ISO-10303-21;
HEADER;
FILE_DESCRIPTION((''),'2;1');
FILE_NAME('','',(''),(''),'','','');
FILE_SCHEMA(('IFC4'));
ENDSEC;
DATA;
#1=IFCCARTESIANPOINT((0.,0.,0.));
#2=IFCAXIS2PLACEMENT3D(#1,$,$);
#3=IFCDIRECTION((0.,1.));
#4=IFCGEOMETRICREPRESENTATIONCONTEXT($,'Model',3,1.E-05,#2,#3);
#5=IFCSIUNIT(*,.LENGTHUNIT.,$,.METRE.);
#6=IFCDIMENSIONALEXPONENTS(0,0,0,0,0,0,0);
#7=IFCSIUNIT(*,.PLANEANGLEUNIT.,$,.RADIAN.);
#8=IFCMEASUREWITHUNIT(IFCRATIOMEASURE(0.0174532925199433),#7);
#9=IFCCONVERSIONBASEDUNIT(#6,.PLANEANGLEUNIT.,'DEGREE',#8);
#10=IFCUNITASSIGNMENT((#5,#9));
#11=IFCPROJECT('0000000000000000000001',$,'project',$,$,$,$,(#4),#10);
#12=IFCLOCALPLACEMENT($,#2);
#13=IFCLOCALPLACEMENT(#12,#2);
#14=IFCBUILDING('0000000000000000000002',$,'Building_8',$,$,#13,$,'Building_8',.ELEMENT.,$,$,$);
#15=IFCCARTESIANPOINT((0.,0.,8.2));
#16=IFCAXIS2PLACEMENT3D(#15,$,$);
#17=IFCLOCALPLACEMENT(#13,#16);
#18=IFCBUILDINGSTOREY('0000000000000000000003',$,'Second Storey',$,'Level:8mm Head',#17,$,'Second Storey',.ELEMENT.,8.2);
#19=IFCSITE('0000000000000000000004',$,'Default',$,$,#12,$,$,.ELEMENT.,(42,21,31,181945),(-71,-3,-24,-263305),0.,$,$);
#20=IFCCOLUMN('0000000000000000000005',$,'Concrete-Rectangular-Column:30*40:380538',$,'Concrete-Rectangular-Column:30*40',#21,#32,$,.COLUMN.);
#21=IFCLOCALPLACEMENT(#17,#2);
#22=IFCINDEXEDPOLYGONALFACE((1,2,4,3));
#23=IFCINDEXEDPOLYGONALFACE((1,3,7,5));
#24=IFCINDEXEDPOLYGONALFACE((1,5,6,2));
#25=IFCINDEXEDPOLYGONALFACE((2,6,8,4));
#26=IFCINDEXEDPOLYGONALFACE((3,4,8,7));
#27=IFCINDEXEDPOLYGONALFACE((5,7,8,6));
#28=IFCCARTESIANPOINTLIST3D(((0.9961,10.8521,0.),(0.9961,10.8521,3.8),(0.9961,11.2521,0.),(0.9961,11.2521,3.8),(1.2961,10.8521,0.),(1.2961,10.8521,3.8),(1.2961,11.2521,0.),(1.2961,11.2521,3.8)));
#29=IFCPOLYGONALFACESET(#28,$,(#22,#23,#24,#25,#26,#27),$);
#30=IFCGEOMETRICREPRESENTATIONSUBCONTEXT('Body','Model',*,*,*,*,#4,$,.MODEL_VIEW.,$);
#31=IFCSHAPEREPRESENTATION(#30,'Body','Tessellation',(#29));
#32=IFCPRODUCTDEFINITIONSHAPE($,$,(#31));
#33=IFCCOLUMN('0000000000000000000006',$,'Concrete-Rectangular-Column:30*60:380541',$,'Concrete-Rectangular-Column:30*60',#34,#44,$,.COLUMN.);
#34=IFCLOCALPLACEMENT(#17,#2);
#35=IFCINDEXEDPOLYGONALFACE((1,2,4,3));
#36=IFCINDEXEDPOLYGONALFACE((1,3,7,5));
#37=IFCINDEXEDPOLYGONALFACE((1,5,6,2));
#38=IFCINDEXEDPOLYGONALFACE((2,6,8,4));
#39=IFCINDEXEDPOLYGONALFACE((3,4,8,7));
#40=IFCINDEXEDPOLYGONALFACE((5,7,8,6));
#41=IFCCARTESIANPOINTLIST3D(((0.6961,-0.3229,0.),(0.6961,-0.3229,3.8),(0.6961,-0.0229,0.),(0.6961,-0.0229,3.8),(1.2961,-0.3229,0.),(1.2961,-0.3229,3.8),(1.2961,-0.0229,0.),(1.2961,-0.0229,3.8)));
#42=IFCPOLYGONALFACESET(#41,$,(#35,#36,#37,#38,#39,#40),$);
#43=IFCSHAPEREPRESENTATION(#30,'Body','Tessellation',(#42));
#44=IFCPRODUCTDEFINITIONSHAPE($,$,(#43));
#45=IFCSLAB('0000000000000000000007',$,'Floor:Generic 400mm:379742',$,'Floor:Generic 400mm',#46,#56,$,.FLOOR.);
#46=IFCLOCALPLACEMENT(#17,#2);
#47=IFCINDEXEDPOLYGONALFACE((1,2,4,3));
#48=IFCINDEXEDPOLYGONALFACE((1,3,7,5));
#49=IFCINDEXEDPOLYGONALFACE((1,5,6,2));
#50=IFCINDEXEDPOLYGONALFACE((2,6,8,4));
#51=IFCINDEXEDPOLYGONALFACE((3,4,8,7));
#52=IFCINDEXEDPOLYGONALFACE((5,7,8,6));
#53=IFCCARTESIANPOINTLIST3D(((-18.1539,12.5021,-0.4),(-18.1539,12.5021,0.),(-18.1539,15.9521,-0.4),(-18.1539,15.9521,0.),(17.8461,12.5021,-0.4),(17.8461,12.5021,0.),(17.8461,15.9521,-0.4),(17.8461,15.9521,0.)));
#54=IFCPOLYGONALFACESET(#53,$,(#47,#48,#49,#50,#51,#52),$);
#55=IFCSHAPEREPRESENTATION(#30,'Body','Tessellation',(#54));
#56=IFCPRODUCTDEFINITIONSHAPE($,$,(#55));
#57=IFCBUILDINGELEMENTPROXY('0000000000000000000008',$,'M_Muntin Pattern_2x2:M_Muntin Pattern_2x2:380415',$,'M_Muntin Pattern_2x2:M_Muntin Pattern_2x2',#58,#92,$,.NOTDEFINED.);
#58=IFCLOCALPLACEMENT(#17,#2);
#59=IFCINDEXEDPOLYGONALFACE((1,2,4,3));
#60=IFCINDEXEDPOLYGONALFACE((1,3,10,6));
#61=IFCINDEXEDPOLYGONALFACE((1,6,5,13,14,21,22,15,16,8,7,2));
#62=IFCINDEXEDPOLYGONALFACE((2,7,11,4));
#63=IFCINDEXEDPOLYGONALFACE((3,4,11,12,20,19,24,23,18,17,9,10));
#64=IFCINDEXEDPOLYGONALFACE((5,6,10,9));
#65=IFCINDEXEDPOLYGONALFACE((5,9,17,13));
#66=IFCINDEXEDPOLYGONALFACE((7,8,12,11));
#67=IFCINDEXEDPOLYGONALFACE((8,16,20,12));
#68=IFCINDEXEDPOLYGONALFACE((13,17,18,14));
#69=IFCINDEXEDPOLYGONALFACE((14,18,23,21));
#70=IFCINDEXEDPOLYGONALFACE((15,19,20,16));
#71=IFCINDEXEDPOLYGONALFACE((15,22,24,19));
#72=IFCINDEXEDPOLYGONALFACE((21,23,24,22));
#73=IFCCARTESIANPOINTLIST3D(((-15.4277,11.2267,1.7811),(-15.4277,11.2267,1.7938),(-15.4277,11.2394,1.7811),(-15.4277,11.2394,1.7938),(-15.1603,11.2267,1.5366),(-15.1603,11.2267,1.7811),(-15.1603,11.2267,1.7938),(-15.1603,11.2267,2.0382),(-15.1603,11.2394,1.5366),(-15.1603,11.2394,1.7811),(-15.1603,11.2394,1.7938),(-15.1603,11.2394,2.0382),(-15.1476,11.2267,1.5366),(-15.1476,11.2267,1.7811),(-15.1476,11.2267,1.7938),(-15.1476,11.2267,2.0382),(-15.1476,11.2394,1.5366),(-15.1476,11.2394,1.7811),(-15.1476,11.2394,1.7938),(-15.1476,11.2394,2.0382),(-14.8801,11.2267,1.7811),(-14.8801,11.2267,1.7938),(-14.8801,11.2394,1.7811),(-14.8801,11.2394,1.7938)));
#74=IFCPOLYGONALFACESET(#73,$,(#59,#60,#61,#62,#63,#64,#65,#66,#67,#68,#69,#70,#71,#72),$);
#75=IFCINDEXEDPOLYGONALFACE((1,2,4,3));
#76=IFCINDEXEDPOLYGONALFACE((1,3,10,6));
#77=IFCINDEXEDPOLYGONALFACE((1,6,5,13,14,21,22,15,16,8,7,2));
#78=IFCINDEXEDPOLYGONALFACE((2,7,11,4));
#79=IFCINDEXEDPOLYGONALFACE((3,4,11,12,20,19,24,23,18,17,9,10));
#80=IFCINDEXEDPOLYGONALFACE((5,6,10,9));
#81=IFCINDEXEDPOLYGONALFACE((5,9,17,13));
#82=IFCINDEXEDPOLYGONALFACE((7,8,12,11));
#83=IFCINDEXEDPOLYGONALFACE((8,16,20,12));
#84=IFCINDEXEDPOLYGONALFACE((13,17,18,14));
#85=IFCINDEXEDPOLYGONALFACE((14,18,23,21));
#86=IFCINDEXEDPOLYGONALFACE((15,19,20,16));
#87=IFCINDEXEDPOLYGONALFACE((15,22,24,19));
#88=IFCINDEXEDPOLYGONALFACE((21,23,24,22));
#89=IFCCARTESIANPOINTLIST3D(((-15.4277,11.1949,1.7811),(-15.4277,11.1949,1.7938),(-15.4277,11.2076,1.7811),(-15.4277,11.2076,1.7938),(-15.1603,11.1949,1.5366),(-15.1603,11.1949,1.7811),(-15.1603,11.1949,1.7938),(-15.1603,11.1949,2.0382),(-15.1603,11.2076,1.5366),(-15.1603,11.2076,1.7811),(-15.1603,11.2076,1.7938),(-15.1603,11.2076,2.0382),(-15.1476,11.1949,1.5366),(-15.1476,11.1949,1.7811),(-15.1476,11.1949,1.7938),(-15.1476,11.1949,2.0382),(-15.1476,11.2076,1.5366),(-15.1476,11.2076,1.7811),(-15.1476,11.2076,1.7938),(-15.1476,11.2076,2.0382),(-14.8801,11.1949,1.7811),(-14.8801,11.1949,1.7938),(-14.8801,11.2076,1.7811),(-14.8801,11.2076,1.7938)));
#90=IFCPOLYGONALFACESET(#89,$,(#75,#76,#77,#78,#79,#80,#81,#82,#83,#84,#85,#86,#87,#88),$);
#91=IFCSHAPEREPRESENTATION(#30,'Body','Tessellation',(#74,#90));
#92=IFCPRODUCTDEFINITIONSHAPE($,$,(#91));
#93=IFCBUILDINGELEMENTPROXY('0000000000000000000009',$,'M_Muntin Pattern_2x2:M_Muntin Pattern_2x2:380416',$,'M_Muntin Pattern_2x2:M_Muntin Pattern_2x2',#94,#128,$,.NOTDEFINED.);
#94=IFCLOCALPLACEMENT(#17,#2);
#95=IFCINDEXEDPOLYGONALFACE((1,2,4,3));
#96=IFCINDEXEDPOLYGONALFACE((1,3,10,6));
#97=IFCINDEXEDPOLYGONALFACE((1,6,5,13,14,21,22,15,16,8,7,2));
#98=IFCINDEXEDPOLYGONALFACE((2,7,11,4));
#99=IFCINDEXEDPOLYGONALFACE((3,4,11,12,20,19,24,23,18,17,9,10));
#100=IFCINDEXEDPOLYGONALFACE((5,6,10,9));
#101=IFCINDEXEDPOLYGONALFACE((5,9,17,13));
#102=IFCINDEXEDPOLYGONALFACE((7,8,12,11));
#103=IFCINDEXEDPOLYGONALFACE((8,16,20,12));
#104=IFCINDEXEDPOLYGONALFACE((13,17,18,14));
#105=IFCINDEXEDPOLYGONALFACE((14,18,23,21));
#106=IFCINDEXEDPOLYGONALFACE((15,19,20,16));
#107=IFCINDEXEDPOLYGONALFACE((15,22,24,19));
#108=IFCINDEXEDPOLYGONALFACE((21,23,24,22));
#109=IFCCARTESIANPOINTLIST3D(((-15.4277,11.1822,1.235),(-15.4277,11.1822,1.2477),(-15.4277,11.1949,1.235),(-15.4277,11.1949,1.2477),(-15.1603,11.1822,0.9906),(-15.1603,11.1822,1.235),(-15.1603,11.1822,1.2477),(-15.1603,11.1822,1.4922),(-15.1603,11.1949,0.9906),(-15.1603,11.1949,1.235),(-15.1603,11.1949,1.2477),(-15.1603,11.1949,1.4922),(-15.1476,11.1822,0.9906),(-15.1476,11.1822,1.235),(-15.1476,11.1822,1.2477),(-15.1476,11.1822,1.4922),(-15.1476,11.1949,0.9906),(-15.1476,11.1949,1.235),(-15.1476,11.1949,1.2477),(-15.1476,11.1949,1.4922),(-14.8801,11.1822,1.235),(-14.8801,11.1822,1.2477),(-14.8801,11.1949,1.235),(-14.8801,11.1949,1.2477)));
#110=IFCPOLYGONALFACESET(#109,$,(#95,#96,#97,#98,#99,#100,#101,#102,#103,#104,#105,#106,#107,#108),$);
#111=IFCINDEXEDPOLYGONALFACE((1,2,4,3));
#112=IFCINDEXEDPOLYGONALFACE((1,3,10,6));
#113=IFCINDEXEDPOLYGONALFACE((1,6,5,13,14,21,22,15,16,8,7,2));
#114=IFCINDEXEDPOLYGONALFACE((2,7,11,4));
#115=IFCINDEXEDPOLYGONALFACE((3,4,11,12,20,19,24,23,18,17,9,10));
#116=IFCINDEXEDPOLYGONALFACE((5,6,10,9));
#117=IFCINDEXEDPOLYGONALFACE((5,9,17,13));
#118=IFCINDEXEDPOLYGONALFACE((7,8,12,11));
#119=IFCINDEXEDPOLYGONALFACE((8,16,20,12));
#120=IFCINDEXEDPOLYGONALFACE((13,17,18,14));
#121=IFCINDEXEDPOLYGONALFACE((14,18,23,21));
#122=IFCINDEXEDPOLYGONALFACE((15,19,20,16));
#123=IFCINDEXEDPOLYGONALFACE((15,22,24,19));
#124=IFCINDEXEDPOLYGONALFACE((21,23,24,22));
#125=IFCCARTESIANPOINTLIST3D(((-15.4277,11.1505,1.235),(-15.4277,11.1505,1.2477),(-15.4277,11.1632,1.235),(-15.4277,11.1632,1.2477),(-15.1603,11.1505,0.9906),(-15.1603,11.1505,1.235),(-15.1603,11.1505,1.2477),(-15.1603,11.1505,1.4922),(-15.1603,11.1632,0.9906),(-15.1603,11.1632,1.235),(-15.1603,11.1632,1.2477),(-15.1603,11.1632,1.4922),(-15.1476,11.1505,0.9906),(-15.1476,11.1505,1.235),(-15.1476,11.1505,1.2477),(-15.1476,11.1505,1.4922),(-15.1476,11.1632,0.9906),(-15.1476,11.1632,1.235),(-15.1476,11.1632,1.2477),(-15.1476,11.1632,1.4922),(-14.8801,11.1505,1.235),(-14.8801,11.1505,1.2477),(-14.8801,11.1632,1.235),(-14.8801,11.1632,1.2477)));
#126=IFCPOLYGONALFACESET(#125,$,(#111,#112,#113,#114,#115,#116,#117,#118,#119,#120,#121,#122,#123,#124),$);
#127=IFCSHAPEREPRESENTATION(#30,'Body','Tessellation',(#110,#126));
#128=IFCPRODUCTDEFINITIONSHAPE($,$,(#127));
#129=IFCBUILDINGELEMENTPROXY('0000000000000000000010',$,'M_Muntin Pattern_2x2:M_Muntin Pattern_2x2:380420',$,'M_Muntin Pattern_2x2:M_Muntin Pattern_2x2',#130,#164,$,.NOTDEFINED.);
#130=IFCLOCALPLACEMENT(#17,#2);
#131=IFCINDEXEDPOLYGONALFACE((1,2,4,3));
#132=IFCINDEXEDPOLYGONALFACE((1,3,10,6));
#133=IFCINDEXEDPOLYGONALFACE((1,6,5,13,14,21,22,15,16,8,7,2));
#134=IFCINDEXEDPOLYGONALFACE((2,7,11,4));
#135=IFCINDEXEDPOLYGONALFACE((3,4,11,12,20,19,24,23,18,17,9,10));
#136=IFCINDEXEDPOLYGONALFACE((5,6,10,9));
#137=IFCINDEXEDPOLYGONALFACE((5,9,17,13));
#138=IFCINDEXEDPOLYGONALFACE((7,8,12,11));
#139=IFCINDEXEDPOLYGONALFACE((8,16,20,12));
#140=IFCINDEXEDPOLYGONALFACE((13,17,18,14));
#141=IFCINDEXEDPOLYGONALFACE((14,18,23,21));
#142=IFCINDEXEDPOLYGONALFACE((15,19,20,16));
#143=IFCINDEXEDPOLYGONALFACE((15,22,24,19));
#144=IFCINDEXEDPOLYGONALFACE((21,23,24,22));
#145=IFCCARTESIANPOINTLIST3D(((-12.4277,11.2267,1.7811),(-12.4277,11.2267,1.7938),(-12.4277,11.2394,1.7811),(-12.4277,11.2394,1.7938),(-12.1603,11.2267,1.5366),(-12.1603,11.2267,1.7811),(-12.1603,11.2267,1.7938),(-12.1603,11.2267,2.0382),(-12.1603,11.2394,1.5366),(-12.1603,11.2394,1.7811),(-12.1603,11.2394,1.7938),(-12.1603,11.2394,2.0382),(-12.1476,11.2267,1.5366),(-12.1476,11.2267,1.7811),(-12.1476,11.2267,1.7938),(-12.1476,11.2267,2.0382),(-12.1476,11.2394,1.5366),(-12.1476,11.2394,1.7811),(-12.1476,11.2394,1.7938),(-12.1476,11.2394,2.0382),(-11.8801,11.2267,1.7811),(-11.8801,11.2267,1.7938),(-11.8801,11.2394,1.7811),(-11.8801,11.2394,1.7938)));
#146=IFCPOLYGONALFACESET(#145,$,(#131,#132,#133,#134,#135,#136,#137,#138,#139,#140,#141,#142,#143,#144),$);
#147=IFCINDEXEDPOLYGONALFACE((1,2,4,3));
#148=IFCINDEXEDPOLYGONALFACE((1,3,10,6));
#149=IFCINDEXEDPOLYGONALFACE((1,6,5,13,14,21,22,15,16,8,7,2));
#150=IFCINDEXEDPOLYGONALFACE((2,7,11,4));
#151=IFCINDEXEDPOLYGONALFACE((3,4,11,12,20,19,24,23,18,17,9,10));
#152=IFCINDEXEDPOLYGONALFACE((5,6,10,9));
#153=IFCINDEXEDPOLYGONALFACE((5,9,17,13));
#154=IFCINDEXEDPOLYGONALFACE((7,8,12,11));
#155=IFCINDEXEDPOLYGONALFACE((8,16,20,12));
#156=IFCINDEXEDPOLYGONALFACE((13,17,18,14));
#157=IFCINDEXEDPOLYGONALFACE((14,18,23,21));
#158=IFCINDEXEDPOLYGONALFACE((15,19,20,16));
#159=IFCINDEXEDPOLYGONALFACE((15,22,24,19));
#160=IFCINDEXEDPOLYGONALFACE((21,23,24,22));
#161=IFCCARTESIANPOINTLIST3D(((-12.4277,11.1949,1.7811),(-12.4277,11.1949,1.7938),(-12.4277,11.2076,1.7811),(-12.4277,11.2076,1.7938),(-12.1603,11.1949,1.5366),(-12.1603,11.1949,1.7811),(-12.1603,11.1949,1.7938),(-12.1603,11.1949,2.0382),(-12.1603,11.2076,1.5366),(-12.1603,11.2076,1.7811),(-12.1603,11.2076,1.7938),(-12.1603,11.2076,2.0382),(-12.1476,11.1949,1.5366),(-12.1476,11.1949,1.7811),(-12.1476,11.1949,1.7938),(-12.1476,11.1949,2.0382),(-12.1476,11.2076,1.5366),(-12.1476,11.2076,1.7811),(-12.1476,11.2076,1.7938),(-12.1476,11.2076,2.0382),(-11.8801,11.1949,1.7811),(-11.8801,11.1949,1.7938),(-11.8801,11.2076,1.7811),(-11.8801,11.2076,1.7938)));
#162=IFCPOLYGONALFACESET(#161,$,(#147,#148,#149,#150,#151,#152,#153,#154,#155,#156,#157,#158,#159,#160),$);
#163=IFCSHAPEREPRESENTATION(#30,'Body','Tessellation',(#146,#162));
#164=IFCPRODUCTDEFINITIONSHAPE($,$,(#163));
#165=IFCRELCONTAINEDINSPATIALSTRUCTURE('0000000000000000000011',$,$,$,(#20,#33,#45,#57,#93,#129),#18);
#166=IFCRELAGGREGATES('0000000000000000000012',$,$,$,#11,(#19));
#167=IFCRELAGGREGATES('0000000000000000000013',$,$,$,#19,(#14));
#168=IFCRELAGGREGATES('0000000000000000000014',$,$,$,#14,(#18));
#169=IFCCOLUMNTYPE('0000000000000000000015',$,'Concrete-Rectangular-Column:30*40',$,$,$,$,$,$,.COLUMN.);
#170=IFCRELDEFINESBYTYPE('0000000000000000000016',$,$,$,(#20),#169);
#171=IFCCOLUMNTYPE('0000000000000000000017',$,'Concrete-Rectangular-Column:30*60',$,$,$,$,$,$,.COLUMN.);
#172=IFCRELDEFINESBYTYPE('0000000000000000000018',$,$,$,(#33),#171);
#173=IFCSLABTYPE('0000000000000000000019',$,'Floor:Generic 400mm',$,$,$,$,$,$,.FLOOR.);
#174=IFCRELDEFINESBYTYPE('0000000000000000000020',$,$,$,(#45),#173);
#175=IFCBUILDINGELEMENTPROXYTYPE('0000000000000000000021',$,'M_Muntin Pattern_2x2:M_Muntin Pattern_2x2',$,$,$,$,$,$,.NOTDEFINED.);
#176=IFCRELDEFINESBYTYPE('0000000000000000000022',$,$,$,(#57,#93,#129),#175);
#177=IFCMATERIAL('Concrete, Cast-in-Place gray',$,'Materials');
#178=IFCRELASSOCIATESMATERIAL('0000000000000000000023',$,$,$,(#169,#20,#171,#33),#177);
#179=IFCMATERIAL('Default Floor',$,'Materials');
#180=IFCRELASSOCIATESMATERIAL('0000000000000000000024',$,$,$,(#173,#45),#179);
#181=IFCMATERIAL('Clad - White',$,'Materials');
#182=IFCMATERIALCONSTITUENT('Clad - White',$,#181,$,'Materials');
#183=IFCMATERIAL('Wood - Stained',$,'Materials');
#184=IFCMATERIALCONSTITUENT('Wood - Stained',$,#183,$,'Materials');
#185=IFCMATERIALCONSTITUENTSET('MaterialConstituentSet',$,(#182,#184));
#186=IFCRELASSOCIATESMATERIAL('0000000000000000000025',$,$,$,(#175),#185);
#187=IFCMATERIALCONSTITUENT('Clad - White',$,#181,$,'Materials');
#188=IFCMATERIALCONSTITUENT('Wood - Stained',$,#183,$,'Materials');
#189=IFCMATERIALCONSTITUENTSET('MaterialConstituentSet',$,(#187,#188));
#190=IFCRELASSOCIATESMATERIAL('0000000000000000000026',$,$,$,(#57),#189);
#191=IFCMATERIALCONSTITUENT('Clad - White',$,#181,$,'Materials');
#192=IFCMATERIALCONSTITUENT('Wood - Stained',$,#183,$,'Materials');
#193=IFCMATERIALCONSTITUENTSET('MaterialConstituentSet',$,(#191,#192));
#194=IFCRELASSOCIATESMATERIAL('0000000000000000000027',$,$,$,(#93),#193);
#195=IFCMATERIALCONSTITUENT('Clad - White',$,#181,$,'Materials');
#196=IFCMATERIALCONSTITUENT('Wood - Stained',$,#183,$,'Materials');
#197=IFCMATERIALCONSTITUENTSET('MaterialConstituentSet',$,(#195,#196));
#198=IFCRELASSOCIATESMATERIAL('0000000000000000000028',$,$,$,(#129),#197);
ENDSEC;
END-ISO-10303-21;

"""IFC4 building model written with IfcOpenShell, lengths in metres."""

from ifc_helpers import new_model, entity, si_unit, converted_unit, direction, frame, origin, place, context, subcontext, project, spatial, indexed_curve, outline, extrude, source, transform, mapped, material, constituent, constituent_set, type_object, type_shapes, element, save


model = new_model("IFC4")

# Units and contexts
model_context = context("Model", 3, precision=1e-05, world=origin(), true_north=direction((0.0, 1.0)))
body_context = subcontext(model_context, "Body", "Model", "MODEL_VIEW")
ifc_project = project(units=[si_unit("LENGTHUNIT", "METRE"), converted_unit("PLANEANGLEUNIT", "DEGREE", entity("IfcRatioMeasure", 0.0174532925199433), si_unit("PLANEANGLEUNIT", "RADIAN"), dimensions=[0, 0, 0, 0, 0, 0, 0])], contexts=[model_context])

# Site, building, storey
site_placement = place(None, origin())
site = spatial("IfcSite", under=ifc_project, at=site_placement, Name="Default", CompositionType="ELEMENT", RefLatitude=(42, 21, 31, 181945), RefLongitude=(-71, -3, -24, -263305), RefElevation=0.0)
building_placement = place(site_placement, origin())
building = spatial("IfcBuilding", under=site, at=building_placement, Name="Building_8", LongName="Building_8", CompositionType="ELEMENT")
storey_placement = place(building_placement, frame((0.0, 0.0, 8.2)))
storey = spatial("IfcBuildingStorey", under=building, at=storey_placement, Name="Second Storey", ObjectType="Level:8mm Head", LongName="Second Storey", CompositionType="ELEMENT", Elevation=8.2)

# Columns
ifc_material_1 = material(Name="Concrete, Cast-in-Place gray", Category="Materials")
column_type_1 = type_object("IfcColumnType", Name="Concrete-Rectangular-Column:30*40", PredefinedType="COLUMN", material=ifc_material_1)
shared_shape_1 = source(origin(), body_context, "Body", "SweptSolid", [
    extrude(outline(indexed_curve([(-0.2, -0.15), (0.2, -0.15), (0.2, 0.15), (-0.2, 0.15), (-0.2, -0.15)], self_intersect=False)), frame((1.1461, 11.0521, 8.2), z_axis=(0.0, 0.0, 1.0), x_axis=(0.0, -1.0, 0.0)), (0.0, 0.0, 1.0), 3.8),
])
type_shapes(column_type_1, [shared_shape_1])
column_1_placement = place(storey_placement, frame((0.0, 0.0, -8.2)))
element("IfcColumn", 1, at=column_1_placement, inside=storey, type_object=column_type_1, material=ifc_material_1, Name="Concrete-Rectangular-Column:30*40:380538", ObjectType="Concrete-Rectangular-Column:30*40", PredefinedType="COLUMN", context=body_context, shape_type="MappedRepresentation", body=[
    mapped(shared_shape_1, transform((0.0, 0.0, 0.0), scale=1.0)),
])
column_type_2 = type_object("IfcColumnType", Name="Concrete-Rectangular-Column:30*60", PredefinedType="COLUMN", material=ifc_material_1)
shared_shape_2 = source(origin(), body_context, "Body", "SweptSolid", [
    extrude(outline(indexed_curve([(-0.15, -0.3), (0.15, -0.3), (0.15, 0.3), (-0.15, 0.3), (-0.15, -0.3)], self_intersect=False)), frame((0.9961, -0.1729, 8.2), z_axis=(0.0, 0.0, 1.0), x_axis=(0.0, -1.0, 0.0)), (0.0, 0.0, 1.0), 3.8),
])
type_shapes(column_type_2, [shared_shape_2])
column_2_placement = place(storey_placement, frame((0.0, 0.0, -8.2)))
element("IfcColumn", 2, at=column_2_placement, inside=storey, type_object=column_type_2, material=ifc_material_1, Name="Concrete-Rectangular-Column:30*60:380541", ObjectType="Concrete-Rectangular-Column:30*60", PredefinedType="COLUMN", context=body_context, shape_type="MappedRepresentation", body=[
    mapped(shared_shape_2, transform((0.0, 0.0, 0.0), scale=1.0)),
])

# Slab
ifc_material_2 = material(Name="Default Floor", Category="Materials")
slab_type_1 = type_object("IfcSlabType", Name="Floor:Generic 400mm", PredefinedType="FLOOR", material=ifc_material_2)
slab_1_placement = place(storey_placement, origin())
element("IfcSlab", 3, at=slab_1_placement, inside=storey, type_object=slab_type_1, material=ifc_material_2, Name="Floor:Generic 400mm:379742", ObjectType="Floor:Generic 400mm", PredefinedType="FLOOR", context=body_context, shape_type="SweptSolid", body=[
    extrude(outline(indexed_curve([(-1.725, -18.0), (1.725, -18.0), (1.725, 18.0), (-1.725, 18.0), (-1.725, -18.0)], self_intersect=False)), frame((-0.1539, 14.2271, 0.0), z_axis=(0.0, 0.0, -1.0), x_axis=(0.0, 1.0, 0.0)), (0.0, 0.0, 1.0), 0.4),
])

# Building element proxies
ifc_material_3 = material(Name="Clad - White", Category="Materials")
ifc_constituent_1 = constituent(ifc_material_3, Name="Clad - White", Category="Materials")
ifc_material_4 = material(Name="Wood - Stained", Category="Materials")
ifc_constituent_2 = constituent(ifc_material_4, Name="Wood - Stained", Category="Materials")
ifc_constituent_set_1 = constituent_set(constituents=[ifc_constituent_1, ifc_constituent_2], Name="MaterialConstituentSet")
ifc_constituent_3 = constituent(ifc_material_3, Name="Clad - White", Category="Materials")
ifc_constituent_4 = constituent(ifc_material_4, Name="Wood - Stained", Category="Materials")
ifc_constituent_set_2 = constituent_set(constituents=[ifc_constituent_3, ifc_constituent_4], Name="MaterialConstituentSet")
building_element_proxy_type_1 = type_object("IfcBuildingElementProxyType", Name="M_Muntin Pattern_2x2:M_Muntin Pattern_2x2", PredefinedType="NOTDEFINED", material=ifc_constituent_set_2)
shared_shape_3 = source(origin(), body_context, "Body", "SweptSolid", [
    extrude(outline(indexed_curve([(0.0064, -0.0064), (0.2508, -0.0064), (0.2508, 0.0063), (0.0064, 0.0063), (0.0064, 0.2738), (-0.0063, 0.2738), (-0.0063, 0.0063), (-0.2508, 0.0063), (-0.2508, -0.0064), (-0.0063, -0.0064), (-0.0063, -0.2738), (0.0064, -0.2738), (0.0064, -0.0064)], self_intersect=False)), frame((0.0, -0.0222, 0.2508), z_axis=(0.0, 1.0, 0.0), x_axis=(0.0, 0.0, 1.0)), (0.0, 0.0, 1.0), 0.0127),
    extrude(outline(indexed_curve([(0.0064, -0.0064), (0.2508, -0.0064), (0.2508, 0.0063), (0.0064, 0.0063), (0.0064, 0.2738), (-0.0063, 0.2738), (-0.0063, 0.0063), (-0.2508, 0.0063), (-0.2508, -0.0064), (-0.0063, -0.0064), (-0.0063, -0.2738), (0.0064, -0.2738), (0.0064, -0.0064)], self_intersect=False)), frame((0.0, 0.0095, 0.2508), z_axis=(0.0, 1.0, 0.0), x_axis=(0.0, 0.0, 1.0)), (0.0, 0.0, 1.0), 0.0127),
])
type_shapes(building_element_proxy_type_1, [shared_shape_3])
proxy_1_placement = place(storey_placement, frame((-15.1539, 11.2171, 1.5366), z_axis=(0.0, 0.0, 1.0), x_axis=(-1.0, 0.0, 0.0)))
element("IfcBuildingElementProxy", 4, at=proxy_1_placement, inside=storey, type_object=building_element_proxy_type_1, material=ifc_constituent_set_1, Name="M_Muntin Pattern_2x2:M_Muntin Pattern_2x2:380415", ObjectType="M_Muntin Pattern_2x2:M_Muntin Pattern_2x2", PredefinedType="NOTDEFINED", context=body_context, shape_type="MappedRepresentation", body=[
    mapped(shared_shape_3, transform((0.0, 0.0, 0.0), scale=1.0)),
])
ifc_constituent_5 = constituent(ifc_material_3, Name="Clad - White", Category="Materials")
ifc_constituent_6 = constituent(ifc_material_4, Name="Wood - Stained", Category="Materials")
ifc_constituent_set_3 = constituent_set(constituents=[ifc_constituent_5, ifc_constituent_6], Name="MaterialConstituentSet")
proxy_2_placement = place(storey_placement, frame((-15.1539, 11.1727, 0.9906), z_axis=(0.0, 0.0, 1.0), x_axis=(-1.0, 0.0, 0.0)))
element("IfcBuildingElementProxy", 5, at=proxy_2_placement, inside=storey, type_object=building_element_proxy_type_1, material=ifc_constituent_set_3, Name="M_Muntin Pattern_2x2:M_Muntin Pattern_2x2:380416", ObjectType="M_Muntin Pattern_2x2:M_Muntin Pattern_2x2", PredefinedType="NOTDEFINED", context=body_context, shape_type="MappedRepresentation", body=[
    mapped(shared_shape_3, transform((0.0, 0.0, 0.0), scale=1.0)),
])
ifc_constituent_7 = constituent(ifc_material_3, Name="Clad - White", Category="Materials")
ifc_constituent_8 = constituent(ifc_material_4, Name="Wood - Stained", Category="Materials")
ifc_constituent_set_4 = constituent_set(constituents=[ifc_constituent_7, ifc_constituent_8], Name="MaterialConstituentSet")
proxy_3_placement = place(storey_placement, frame((-12.1539, 11.2171, 1.5366), z_axis=(0.0, 0.0, 1.0), x_axis=(-1.0, 0.0, 0.0)))
element("IfcBuildingElementProxy", 6, at=proxy_3_placement, inside=storey, type_object=building_element_proxy_type_1, material=ifc_constituent_set_4, Name="M_Muntin Pattern_2x2:M_Muntin Pattern_2x2:380420", ObjectType="M_Muntin Pattern_2x2:M_Muntin Pattern_2x2", PredefinedType="NOTDEFINED", context=body_context, shape_type="MappedRepresentation", body=[
    mapped(shared_shape_3, transform((0.0, 0.0, 0.0), scale=1.0)),
])

save(model, "model.ifc")
